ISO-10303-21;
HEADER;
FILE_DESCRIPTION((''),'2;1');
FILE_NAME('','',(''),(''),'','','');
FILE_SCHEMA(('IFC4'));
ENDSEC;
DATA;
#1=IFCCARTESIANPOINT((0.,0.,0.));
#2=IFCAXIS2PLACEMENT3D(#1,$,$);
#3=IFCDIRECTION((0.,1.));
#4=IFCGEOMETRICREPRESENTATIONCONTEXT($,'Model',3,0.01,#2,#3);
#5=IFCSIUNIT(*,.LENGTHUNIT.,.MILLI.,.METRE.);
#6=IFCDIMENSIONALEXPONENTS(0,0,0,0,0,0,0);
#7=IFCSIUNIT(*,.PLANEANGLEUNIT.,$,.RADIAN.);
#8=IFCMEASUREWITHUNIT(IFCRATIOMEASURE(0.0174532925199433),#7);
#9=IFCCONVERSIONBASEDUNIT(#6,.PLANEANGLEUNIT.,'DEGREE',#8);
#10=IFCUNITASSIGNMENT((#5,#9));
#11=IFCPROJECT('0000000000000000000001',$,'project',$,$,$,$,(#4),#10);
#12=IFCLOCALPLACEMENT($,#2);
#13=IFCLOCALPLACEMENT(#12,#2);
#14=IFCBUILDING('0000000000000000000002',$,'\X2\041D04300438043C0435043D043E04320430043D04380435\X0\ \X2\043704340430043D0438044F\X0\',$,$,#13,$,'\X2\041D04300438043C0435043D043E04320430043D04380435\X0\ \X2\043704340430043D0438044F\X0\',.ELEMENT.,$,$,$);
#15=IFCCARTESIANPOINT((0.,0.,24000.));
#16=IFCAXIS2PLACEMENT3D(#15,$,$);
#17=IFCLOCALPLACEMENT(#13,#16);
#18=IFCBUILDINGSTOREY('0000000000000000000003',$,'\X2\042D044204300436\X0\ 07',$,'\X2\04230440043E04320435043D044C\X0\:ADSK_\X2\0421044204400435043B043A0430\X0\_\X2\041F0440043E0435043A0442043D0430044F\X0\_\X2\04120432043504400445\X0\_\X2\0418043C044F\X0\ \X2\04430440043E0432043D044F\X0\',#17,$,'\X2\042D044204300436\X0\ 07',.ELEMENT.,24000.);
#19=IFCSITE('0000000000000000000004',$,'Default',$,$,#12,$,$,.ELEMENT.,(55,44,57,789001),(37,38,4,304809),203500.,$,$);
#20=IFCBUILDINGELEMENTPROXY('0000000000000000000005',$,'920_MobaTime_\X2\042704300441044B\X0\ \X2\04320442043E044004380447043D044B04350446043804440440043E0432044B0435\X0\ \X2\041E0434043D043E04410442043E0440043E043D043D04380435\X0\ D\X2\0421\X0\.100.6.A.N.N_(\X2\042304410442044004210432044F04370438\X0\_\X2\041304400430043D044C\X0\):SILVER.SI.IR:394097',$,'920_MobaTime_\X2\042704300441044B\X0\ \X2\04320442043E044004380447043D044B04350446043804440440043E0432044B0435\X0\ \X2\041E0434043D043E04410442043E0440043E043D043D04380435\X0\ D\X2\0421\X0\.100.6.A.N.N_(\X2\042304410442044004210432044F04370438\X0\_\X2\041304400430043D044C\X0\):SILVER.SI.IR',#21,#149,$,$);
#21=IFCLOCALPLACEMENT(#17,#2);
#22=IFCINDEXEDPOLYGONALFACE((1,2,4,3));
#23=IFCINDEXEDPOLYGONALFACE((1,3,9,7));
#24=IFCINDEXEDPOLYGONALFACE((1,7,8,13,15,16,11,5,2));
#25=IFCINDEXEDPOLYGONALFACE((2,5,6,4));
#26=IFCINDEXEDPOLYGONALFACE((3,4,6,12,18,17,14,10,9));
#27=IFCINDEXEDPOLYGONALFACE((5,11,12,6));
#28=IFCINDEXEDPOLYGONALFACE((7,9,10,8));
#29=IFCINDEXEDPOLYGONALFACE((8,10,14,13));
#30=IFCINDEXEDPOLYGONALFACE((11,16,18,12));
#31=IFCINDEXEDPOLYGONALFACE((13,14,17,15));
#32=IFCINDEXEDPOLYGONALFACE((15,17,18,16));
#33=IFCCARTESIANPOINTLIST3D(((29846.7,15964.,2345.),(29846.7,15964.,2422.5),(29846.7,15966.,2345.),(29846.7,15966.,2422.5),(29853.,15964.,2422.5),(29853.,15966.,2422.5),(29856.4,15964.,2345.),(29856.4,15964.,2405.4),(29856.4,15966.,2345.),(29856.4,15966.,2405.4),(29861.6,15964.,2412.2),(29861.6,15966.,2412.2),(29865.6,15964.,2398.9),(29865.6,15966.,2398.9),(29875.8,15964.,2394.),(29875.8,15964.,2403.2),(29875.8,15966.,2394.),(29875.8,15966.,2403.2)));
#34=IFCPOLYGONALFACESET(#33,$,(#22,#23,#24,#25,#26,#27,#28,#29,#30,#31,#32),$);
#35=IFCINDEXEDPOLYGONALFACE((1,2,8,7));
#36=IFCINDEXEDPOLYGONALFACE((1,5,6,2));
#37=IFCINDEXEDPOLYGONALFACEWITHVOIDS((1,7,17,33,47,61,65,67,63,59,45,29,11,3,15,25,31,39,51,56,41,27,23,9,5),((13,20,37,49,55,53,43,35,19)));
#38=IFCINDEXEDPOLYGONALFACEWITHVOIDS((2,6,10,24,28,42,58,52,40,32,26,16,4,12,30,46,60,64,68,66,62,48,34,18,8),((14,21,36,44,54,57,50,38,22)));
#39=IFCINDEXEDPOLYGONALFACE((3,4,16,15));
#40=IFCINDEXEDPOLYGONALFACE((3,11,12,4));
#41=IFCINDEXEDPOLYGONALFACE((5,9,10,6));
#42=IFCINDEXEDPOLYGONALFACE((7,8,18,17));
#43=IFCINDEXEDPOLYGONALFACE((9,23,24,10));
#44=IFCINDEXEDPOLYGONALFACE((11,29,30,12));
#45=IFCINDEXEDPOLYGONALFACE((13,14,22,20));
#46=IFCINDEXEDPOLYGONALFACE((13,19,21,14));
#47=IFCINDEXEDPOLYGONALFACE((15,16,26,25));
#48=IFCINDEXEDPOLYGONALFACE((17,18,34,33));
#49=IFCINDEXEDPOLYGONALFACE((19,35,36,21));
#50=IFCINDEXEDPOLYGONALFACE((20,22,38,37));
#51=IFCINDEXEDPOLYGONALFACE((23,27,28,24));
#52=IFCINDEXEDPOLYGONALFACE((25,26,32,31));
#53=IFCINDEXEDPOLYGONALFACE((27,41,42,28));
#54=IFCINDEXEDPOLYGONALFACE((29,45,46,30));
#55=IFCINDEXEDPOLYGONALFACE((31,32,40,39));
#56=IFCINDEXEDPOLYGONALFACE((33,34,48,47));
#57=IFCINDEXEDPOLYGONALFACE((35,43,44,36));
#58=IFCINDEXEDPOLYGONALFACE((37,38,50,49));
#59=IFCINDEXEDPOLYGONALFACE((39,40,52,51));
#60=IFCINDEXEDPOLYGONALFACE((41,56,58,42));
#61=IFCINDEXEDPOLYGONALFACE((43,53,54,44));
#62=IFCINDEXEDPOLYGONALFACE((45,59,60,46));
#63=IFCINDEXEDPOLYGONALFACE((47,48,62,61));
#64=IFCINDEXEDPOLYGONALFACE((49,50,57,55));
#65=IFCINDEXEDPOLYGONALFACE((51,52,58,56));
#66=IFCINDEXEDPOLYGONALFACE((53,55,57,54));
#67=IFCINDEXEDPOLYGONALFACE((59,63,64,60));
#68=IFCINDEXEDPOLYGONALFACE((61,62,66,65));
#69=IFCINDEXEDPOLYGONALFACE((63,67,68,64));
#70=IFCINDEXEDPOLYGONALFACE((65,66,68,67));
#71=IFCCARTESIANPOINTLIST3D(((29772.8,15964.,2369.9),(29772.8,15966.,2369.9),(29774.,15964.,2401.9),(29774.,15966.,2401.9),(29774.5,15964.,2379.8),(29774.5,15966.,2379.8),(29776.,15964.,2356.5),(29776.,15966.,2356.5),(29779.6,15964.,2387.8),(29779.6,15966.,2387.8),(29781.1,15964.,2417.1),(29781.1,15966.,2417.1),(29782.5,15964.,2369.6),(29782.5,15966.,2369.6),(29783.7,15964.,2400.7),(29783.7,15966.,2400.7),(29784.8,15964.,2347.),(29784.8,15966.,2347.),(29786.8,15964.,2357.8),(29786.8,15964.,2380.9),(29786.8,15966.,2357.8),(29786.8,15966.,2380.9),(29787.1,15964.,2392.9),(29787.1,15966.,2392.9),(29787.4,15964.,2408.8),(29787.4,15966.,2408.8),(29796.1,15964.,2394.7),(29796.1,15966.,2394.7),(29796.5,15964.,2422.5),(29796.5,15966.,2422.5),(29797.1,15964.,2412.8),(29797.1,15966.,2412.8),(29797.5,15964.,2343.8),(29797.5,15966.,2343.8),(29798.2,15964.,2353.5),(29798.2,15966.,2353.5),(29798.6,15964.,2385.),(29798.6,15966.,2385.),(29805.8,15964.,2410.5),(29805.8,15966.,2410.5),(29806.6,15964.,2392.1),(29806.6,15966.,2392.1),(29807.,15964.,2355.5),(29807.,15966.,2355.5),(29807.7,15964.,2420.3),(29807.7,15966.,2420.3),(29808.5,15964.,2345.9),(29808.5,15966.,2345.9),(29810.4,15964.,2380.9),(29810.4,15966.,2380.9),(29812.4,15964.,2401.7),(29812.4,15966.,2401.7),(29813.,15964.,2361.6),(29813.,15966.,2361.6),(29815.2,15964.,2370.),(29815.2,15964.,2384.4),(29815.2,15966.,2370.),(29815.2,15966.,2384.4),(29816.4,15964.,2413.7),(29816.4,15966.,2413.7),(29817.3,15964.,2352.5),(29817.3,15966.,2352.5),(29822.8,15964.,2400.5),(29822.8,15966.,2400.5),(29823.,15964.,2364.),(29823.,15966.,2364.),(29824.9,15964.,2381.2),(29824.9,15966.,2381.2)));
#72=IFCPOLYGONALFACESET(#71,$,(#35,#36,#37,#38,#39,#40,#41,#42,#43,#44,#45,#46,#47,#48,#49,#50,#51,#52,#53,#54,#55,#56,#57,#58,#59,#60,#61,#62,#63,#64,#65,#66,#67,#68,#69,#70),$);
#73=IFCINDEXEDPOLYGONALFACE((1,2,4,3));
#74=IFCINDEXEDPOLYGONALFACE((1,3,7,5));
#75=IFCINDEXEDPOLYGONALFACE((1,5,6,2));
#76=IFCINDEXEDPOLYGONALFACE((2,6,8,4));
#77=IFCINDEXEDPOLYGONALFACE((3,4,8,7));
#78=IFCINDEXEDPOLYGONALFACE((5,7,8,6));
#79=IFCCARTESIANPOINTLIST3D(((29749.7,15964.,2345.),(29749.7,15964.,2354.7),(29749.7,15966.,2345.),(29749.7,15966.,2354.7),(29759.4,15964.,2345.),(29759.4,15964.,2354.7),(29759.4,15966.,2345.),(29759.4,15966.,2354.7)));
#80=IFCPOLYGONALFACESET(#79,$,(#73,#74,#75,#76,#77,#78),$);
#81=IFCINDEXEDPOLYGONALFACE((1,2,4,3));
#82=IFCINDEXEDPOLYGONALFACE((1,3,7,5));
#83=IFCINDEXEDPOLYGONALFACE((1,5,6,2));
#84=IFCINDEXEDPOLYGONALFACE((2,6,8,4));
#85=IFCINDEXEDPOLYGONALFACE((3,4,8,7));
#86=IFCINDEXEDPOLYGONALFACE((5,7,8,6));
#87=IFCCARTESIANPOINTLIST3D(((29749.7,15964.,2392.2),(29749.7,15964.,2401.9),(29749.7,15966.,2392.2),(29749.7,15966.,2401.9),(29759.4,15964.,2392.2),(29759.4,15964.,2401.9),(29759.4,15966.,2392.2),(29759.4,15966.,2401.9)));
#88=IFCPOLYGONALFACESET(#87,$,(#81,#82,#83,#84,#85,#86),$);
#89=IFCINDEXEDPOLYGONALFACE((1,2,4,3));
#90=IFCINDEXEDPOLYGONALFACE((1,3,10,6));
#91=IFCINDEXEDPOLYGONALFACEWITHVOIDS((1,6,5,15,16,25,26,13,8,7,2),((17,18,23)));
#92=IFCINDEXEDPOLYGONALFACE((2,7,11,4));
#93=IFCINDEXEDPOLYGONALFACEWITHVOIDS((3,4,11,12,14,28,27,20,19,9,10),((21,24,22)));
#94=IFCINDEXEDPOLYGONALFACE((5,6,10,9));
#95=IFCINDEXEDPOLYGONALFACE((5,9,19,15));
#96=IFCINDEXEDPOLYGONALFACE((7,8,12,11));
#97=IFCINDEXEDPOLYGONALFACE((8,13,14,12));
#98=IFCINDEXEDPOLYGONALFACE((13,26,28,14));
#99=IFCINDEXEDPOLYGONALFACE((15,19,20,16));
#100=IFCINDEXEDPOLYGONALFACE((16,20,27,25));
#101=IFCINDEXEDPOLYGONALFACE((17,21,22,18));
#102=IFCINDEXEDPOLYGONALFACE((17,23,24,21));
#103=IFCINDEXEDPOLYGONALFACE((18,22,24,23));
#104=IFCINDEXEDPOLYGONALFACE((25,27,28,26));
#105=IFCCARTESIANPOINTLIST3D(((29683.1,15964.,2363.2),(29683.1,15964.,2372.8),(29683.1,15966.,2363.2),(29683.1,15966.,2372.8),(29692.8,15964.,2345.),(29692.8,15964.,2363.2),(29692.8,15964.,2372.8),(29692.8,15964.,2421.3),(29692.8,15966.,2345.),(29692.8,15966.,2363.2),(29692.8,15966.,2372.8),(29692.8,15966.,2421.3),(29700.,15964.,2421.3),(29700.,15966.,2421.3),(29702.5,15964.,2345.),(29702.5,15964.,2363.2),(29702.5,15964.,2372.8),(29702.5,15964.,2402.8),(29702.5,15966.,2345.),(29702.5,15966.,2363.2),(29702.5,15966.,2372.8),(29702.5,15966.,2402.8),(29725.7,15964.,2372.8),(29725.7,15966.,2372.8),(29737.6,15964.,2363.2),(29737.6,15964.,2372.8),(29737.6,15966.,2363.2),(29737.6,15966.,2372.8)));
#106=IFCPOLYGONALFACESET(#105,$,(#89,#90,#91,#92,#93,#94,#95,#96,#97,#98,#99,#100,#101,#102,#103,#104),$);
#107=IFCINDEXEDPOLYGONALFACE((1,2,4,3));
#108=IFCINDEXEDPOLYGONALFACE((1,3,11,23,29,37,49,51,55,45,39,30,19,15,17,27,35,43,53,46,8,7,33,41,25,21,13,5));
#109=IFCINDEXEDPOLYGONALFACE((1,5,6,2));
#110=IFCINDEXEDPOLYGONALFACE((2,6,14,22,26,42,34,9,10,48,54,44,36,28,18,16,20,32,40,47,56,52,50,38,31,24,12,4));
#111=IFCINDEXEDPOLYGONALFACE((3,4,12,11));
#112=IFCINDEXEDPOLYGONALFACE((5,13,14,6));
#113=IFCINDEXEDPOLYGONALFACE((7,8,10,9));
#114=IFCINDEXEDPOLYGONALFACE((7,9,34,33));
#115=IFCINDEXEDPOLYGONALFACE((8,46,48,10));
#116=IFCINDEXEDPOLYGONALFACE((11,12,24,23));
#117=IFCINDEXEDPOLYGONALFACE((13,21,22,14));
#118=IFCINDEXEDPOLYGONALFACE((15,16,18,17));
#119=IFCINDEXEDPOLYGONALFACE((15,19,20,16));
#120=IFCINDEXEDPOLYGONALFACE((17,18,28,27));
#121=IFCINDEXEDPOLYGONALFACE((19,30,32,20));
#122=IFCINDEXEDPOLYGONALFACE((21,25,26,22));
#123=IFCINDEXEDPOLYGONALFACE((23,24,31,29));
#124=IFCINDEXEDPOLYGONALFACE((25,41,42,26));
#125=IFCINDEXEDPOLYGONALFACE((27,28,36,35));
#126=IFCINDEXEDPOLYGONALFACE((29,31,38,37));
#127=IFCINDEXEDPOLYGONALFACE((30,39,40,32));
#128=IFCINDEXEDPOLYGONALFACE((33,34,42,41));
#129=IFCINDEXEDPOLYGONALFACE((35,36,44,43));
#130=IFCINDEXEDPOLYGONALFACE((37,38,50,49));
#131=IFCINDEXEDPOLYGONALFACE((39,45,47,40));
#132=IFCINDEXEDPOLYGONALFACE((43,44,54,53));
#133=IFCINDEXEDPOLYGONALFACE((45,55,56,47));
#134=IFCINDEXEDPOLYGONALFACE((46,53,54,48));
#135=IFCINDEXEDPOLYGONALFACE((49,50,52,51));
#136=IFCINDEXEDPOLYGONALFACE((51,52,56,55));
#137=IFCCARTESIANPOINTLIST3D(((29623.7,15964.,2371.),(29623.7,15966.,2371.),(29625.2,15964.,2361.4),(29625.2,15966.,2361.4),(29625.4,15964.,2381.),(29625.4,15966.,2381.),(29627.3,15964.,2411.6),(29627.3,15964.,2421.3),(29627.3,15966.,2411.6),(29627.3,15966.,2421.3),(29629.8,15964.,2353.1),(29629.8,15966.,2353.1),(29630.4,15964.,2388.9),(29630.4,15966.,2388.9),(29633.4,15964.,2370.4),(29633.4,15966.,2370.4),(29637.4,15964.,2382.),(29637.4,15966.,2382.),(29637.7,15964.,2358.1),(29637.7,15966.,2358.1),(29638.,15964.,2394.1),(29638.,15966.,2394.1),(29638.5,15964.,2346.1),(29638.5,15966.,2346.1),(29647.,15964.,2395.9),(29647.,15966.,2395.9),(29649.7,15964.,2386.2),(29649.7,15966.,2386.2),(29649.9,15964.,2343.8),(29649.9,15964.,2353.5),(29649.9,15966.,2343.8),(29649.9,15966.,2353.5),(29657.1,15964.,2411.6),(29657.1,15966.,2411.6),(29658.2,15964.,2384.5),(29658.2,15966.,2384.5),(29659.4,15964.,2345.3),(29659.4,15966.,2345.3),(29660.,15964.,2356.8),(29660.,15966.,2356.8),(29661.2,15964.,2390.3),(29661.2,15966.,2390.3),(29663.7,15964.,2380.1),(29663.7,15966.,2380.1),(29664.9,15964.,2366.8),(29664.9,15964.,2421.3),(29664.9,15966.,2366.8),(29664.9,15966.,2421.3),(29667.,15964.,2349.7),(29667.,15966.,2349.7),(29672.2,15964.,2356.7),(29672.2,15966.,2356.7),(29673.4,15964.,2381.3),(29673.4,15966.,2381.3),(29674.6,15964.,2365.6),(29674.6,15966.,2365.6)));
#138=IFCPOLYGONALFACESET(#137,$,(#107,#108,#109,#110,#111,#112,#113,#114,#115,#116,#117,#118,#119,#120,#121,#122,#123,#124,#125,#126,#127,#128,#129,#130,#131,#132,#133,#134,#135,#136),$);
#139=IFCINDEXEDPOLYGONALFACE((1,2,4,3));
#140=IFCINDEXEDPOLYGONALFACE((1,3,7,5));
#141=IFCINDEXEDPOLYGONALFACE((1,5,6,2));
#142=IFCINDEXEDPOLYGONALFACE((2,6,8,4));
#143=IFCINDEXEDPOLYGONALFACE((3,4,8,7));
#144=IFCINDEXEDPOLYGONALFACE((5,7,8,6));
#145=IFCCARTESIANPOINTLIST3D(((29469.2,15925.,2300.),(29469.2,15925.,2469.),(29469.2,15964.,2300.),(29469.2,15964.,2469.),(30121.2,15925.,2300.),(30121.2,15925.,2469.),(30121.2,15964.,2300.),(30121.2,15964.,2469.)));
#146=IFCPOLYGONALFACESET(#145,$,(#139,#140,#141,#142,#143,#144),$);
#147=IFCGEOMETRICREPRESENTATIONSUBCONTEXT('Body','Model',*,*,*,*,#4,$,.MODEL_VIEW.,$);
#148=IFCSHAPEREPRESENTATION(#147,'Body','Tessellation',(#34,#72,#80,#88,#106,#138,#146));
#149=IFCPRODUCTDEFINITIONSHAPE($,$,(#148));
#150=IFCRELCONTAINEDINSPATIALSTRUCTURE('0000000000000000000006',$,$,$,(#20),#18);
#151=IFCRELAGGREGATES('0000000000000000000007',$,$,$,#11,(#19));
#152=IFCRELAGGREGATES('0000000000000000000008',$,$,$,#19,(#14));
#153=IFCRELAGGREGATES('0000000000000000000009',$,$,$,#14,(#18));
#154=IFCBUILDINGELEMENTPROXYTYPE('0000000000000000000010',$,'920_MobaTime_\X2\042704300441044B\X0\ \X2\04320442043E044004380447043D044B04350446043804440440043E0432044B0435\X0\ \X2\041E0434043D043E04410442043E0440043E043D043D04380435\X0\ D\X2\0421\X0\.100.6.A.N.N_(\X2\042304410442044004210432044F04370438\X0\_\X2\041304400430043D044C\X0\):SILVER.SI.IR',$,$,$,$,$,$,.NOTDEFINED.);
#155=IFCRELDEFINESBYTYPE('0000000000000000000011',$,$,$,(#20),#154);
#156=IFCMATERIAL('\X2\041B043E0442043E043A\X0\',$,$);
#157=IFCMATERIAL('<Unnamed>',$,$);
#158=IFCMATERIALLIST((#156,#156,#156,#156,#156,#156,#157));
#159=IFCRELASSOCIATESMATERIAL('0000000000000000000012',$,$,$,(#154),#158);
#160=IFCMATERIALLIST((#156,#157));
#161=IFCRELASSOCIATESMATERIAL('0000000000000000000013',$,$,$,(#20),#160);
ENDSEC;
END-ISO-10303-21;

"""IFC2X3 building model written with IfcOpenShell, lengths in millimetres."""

from ifc_helpers import new_model, entity, si_unit, converted_unit, direction, frame, origin, origin_2d_with_axis, place, context, subcontext, project, spatial, polyline, rectangle, outline, extrude, source, transform, mapped, material, material_list, type_object, type_shapes, element, save


model = new_model("IFC2X3")

# Units and contexts
model_context = context("Model", 3, precision=0.01, world=origin(), true_north=direction((0.0, 1.0)))
body_context = subcontext(model_context, "Body", "Model", "MODEL_VIEW")
ifc_project = project(units=[si_unit("LENGTHUNIT", "METRE", prefix="MILLI"), converted_unit("PLANEANGLEUNIT", "DEGREE", entity("IfcRatioMeasure", 0.0174532925199433), si_unit("PLANEANGLEUNIT", "RADIAN"), dimensions=[0, 0, 0, 0, 0, 0, 0])], contexts=[model_context])

# Site, building, storey
site_placement = place(None, frame((0.0, 0.0, 0.0)))
site = spatial("IfcSite", under=ifc_project, at=site_placement, Name="Default", CompositionType="ELEMENT", RefLatitude=(55, 44, 57, 789001), RefLongitude=(37, 38, 4, 304809), RefElevation=203500.0)
building_placement = place(site_placement, origin())
building = spatial("IfcBuilding", under=site, at=building_placement, Name="Наименование здания", LongName="Наименование здания", CompositionType="ELEMENT")
storey_placement = place(building_placement, frame((0.0, 0.0, 24000.0)))
storey = spatial("IfcBuildingStorey", under=building, at=storey_placement, Name="Этаж 07", ObjectType="Уровень:ADSK_Стрелка_Проектная_Вверх_Имя уровня", LongName="Этаж 07", CompositionType="ELEMENT", Elevation=24000.0)

# Building element proxy
ifc_material_1 = material(Name="Лоток")
ifc_material_2 = material(Name="<Unnamed>")
ifc_material_list_1 = material_list([ifc_material_1, ifc_material_1, ifc_material_1, ifc_material_1, ifc_material_1, ifc_material_1, ifc_material_2])
building_element_proxy_type = type_object("IfcBuildingElementProxyType", Name="920_MobaTime_Часы вторичныецифровые Односторонние DС.100.6.A.N.N_(УстрСвязи_Грань):SILVER.SI.IR", PredefinedType="NOTDEFINED", material=ifc_material_list_1)
shared_shape = source(origin(), body_context, "Body", "SweptSolid", [
    extrude(outline(polyline([(-49.3, -13.1), (28.2, -13.1), (28.2, -6.8), (17.9, 1.8), (8.9, 16.0), (-0.3, 16.0), (4.6, 5.8), (11.1, -3.4), (-49.3, -3.4), (-49.3, -13.1)])), frame((-64.6, 9.8, 39.0), z_axis=(0.0, 0.0, 1.0), x_axis=(0.0, 1.0, 0.0)), (0.0, 0.0, 1.0), 2.0),
    extrude(outline(polyline([(2.2, -27.6), (19.0, -27.6), (30.5, -16.1), (33.3, -4.9), (31.0, 5.8), (21.8, 17.2), (5.2, 27.3), (-11.1, 33.0), (-24.0, 32.7), (-33.6, 27.6), (-40.3, 18.6), (-42.8, 5.7), (-38.0, -6.3), (-27.2, -15.0), (-17.5, -17.7), (-8.2, -16.4), (-0.3, -11.9), (5.1, -4.5), (7.3, 6.2), (4.0, 17.2), (18.5, 7.3), (23.6, -2.4), (22.0, -11.4), (14.2, -18.4), (5.3, -18.3), (2.2, -27.6)]), holes=[polyline([(-9.0, 23.3), (-1.3, 14.4), (-2.6, 2.0), (-11.4, -7.0), (-23.4, -6.1), (-32.2, 2.9), (-31.2, 15.1), (-25.6, 22.1), (-17.5, 24.9), (-9.0, 23.3)])]), frame((-2.7, 3.6, 39.0), z_axis=(0.0, 0.0, 1.0), x_axis=(-0.427649, 0.903945, 0.0)), (0.0, 0.0, 1.0), 2.0),
    extrude(rectangle(XDim=9.7, YDim=9.7, at=origin_2d_with_axis()), frame((40.6, -34.7, 39.0)), (0.0, 0.0, 1.0), 2.0),
    extrude(rectangle(XDim=9.7, YDim=9.7, at=origin_2d_with_axis()), frame((40.6, 12.6, 39.0)), (0.0, 0.0, 1.0), 2.0),
    extrude(outline(polyline([(-0.9, -28.1), (8.8, -28.1), (8.8, -9.9), (18.5, -9.9), (18.5, -0.2), (8.8, -0.2), (8.8, 48.3), (1.5, 48.3), (-36.0, -0.2), (-36.0, -9.9), (-0.9, -9.9), (-0.9, -28.1)]), holes=[polyline([(-0.9, -0.2), (-24.1, -0.2), (-0.9, 29.7), (-0.9, -0.2)])]), frame((93.6, -11.4, 39.0)), (0.0, 0.0, 1.0), 2.0),
    extrude(outline(polyline([(3.3, -28.3), (12.5, -28.3), (20.5, -25.0), (26.8, -18.8), (30.7, -10.0), (31.4, 1.6), (26.9, 11.8), (20.1, 18.4), (11.1, 22.3), (1.0, 23.3), (-7.9, 20.4), (-14.9, 14.5), (-18.9, 6.2), (-17.1, -9.0), (-36.7, 0.5), (-29.1, 29.3), (-38.5, 31.7), (-48.1, -4.6), (-11.6, -23.0), (-8.0, -14.0), (-10.8, -7.6), (-10.2, 1.1), (-3.0, 11.8), (9.2, 12.8), (20.0, 5.4), (21.3, -7.5), (15.5, -16.4), (4.6, -18.6), (3.3, -28.3)])), frame((147.1, -8.5, 39.0), z_axis=(0.0, 0.0, 1.0), x_axis=(0.256974, -0.966418, 0.0)), (0.0, 0.0, 1.0), 2.0),
    extrude(rectangle(XDim=652.0, YDim=169.0, at=origin_2d_with_axis()), frame((0.0, 0.0, 0.0), z_axis=(0.0, 0.0, 1.0), x_axis=(-1.0, 0.0, 0.0)), (0.0, 0.0, 1.0), 39.0),
])
type_shapes(building_element_proxy_type, [shared_shape])
ifc_material_list_2 = material_list([ifc_material_1, ifc_material_2])
proxy_1_placement = place(storey_placement, frame((29795.2, 15925.0, 2384.5), z_axis=(0.0, 1.0, 0.0), x_axis=(-1.0, 0.0, 0.0)))
element("IfcBuildingElementProxy", 1, at=proxy_1_placement, inside=storey, type_object=building_element_proxy_type, material=ifc_material_list_2, Name="920_MobaTime_Часы вторичныецифровые Односторонние DС.100.6.A.N.N_(УстрСвязи_Грань):SILVER.SI.IR:394097", ObjectType="920_MobaTime_Часы вторичныецифровые Односторонние DС.100.6.A.N.N_(УстрСвязи_Грань):SILVER.SI.IR", context=body_context, shape_type="MappedRepresentation", body=[
    mapped(shared_shape, transform((0.0, 0.0, 0.0), scale=1.0)),
])

save(model, "model.ifc")
